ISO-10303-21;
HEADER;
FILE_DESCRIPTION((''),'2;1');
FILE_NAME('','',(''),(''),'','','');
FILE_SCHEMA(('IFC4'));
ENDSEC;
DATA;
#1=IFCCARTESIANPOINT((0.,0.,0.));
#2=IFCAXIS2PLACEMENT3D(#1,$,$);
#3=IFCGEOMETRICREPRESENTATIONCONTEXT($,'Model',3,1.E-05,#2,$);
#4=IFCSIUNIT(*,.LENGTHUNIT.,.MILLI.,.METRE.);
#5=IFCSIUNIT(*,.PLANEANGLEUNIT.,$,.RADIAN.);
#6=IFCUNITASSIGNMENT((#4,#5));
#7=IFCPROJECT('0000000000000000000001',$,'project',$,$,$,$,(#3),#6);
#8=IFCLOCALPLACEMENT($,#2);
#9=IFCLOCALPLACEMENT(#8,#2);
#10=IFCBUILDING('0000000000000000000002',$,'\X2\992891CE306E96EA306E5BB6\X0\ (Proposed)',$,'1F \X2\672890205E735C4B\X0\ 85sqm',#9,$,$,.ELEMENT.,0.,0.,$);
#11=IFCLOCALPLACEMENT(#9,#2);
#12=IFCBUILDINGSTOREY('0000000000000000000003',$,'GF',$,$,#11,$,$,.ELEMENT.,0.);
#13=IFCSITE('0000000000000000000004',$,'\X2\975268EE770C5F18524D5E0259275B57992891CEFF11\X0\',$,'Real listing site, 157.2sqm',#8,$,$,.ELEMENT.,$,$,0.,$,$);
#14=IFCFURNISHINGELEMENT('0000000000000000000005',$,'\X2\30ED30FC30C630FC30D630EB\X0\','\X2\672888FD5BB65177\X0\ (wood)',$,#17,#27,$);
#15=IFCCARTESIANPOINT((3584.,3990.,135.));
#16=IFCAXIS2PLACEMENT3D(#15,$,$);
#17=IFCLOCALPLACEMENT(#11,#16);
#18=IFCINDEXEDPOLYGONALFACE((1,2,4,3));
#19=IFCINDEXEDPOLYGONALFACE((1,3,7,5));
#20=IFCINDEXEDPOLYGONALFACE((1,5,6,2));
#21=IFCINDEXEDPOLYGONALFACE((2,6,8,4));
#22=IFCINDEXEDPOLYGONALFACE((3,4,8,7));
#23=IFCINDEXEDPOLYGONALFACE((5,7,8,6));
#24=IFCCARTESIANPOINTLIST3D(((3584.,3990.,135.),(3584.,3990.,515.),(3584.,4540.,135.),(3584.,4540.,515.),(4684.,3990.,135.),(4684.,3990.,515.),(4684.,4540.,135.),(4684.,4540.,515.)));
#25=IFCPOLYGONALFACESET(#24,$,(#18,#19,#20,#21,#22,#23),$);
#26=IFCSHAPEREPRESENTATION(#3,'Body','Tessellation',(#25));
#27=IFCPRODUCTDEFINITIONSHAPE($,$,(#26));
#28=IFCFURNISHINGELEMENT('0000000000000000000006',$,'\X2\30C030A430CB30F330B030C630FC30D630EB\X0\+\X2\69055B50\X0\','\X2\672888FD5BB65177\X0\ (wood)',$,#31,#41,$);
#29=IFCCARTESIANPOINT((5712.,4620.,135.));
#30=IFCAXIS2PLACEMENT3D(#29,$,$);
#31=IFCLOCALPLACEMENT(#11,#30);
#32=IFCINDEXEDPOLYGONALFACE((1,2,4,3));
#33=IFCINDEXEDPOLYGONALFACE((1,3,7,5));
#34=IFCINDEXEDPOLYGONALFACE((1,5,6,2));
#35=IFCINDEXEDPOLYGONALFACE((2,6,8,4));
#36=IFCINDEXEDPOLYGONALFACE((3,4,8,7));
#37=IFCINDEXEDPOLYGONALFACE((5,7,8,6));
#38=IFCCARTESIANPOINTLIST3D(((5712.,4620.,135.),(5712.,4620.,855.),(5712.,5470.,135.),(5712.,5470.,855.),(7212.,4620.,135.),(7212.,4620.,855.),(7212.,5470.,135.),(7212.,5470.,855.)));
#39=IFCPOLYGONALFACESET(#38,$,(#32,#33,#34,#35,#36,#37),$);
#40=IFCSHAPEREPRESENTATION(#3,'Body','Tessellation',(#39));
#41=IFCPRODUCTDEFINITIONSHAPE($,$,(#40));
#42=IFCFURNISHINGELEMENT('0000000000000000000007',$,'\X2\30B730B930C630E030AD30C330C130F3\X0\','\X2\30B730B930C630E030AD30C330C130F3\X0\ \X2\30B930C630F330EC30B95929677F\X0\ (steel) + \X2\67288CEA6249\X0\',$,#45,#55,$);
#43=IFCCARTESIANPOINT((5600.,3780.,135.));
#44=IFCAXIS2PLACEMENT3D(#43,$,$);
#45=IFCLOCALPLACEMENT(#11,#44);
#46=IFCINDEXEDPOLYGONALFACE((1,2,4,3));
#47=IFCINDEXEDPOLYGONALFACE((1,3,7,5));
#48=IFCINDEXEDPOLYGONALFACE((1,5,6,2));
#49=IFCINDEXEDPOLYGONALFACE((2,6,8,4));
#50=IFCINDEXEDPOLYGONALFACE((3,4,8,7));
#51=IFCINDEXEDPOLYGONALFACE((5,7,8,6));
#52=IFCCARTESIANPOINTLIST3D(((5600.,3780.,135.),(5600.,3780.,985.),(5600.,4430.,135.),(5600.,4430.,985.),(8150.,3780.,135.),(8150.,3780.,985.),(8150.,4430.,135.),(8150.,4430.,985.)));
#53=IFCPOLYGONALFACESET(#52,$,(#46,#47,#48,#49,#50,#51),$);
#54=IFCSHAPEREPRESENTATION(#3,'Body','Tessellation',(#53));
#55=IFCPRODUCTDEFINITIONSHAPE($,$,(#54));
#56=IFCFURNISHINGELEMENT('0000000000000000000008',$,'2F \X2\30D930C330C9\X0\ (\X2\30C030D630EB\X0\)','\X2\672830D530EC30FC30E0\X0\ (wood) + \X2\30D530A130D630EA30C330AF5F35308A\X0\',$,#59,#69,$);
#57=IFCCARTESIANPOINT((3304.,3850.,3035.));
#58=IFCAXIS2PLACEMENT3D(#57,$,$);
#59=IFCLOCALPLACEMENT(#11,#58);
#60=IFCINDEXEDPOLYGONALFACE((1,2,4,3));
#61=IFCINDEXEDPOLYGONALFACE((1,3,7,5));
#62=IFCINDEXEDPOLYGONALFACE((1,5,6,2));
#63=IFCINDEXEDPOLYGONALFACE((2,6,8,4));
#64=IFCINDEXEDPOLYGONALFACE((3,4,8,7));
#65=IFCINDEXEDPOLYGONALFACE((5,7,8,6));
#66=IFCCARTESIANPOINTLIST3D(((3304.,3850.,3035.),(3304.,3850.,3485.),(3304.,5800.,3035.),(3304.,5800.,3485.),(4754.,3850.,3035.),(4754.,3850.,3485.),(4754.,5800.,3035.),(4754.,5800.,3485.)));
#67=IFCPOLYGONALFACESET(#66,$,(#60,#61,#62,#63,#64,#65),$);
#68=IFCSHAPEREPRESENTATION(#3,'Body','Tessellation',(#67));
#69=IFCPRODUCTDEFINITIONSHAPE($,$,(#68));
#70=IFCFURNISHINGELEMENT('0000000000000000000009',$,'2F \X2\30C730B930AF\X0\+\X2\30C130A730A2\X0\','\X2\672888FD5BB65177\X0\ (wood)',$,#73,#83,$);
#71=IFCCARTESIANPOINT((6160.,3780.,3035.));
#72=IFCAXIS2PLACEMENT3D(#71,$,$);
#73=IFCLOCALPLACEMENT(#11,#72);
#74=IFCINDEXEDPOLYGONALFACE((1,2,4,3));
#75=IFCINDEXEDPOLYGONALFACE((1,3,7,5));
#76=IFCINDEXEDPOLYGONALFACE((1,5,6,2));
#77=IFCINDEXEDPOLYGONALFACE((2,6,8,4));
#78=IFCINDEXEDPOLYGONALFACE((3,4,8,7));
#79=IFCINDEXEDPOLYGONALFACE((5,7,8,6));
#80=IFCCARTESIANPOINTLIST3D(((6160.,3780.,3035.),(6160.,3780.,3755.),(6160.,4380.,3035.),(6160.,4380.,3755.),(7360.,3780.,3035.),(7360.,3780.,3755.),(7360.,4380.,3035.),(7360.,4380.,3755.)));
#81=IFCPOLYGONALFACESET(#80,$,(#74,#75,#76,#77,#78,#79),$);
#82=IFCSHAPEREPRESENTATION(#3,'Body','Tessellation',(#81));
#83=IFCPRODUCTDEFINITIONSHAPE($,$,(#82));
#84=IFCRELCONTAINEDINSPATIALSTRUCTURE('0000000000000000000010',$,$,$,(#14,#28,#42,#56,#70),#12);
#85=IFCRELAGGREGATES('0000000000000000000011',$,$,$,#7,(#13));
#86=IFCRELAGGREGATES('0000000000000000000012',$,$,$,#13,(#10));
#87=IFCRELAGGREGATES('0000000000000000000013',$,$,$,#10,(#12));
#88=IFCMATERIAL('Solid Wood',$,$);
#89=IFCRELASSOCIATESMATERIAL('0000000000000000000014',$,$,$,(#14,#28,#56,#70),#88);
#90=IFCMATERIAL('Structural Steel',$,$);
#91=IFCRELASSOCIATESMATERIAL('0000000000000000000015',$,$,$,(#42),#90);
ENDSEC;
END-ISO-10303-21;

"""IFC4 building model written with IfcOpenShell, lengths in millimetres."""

from ifc_helpers import new_model, si_unit, frame, frame_2d, origin, place, context, project, spatial, rectangle, extrude, material, element, save


model = new_model("IFC4")

# Units and contexts
model_context = context("Model", 3, precision=1e-05, world=origin())
ifc_project = project(units=[si_unit("LENGTHUNIT", "METRE", prefix="MILLI"), si_unit("PLANEANGLEUNIT", "RADIAN")], contexts=[model_context])

# Site, building, storey
site_placement = place(None, origin())
site = spatial("IfcSite", under=ifc_project, at=site_placement, Name="青森県弘前市大字館野１", ObjectType="Real listing site, 157.2sqm", CompositionType="ELEMENT", RefElevation=0.0)
building_placement = place(site_placement, origin())
building = spatial("IfcBuilding", under=site, at=building_placement, Name="館野の雪の家 (Proposed)", ObjectType="1F 木造平屋 85sqm", CompositionType="ELEMENT", ElevationOfRefHeight=0.0, ElevationOfTerrain=0.0)
storey_placement = place(building_placement, origin())
storey = spatial("IfcBuildingStorey", under=building, at=storey_placement, Name="GF", CompositionType="ELEMENT", Elevation=0.0)

# Shared definitions
ifc_material_1 = material(Name="Solid Wood")

# Shared definitions
ifc_material_2 = material(Name="Structural Steel")

# Furnishing elements
furnishing_1_placement = place(storey_placement, frame((3584.0, 3990.0, 135.0)))
element("IfcFurnishingElement", 1, at=furnishing_1_placement, inside=storey, material=ifc_material_1, Name="ローテーブル", Description="木製家具 (wood)", context=model_context, shape_type="SweptSolid", body=[
    extrude(rectangle(XDim=1100.0, YDim=550.0, at=frame_2d((550.0, 275.0))), frame((3584.0, 3990.0, 135.0)), (0.0, 0.0, 1.0), 380.0),
])
furnishing_2_placement = place(storey_placement, frame((5712.0, 4620.0, 135.0)))
element("IfcFurnishingElement", 2, at=furnishing_2_placement, inside=storey, material=ifc_material_1, Name="ダイニングテーブル+椅子", Description="木製家具 (wood)", context=model_context, shape_type="SweptSolid", body=[
    extrude(rectangle(XDim=1500.0, YDim=850.0, at=frame_2d((750.0, 425.0))), frame((5712.0, 4620.0, 135.0)), (0.0, 0.0, 1.0), 720.0),
])
furnishing_3_placement = place(storey_placement, frame((5600.0, 3780.0, 135.0)))
element("IfcFurnishingElement", 3, at=furnishing_3_placement, inside=storey, material=ifc_material_2, Name="システムキッチン", Description="システムキッチン ステンレス天板 (steel) + 木質扉", context=model_context, shape_type="SweptSolid", body=[
    extrude(rectangle(XDim=2550.0, YDim=650.0, at=frame_2d((1275.0, 325.0))), frame((5600.0, 3780.0, 135.0)), (0.0, 0.0, 1.0), 850.0),
])
furnishing_4_placement = place(storey_placement, frame((3304.0, 3850.0, 3035.0)))
element("IfcFurnishingElement", 4, at=furnishing_4_placement, inside=storey, material=ifc_material_1, Name="2F ベッド (ダブル)", Description="木フレーム (wood) + ファブリック張り", context=model_context, shape_type="SweptSolid", body=[
    extrude(rectangle(XDim=1450.0, YDim=1950.0, at=frame_2d((725.0, 975.0))), frame((3304.0, 3850.0, 3035.0)), (0.0, 0.0, 1.0), 450.0),
])
furnishing_5_placement = place(storey_placement, frame((6160.0, 3780.0, 3035.0)))
element("IfcFurnishingElement", 5, at=furnishing_5_placement, inside=storey, material=ifc_material_1, Name="2F デスク+チェア", Description="木製家具 (wood)", context=model_context, shape_type="SweptSolid", body=[
    extrude(rectangle(XDim=1200.0, YDim=600.0, at=frame_2d((600.0, 300.0))), frame((6160.0, 3780.0, 3035.0)), (0.0, 0.0, 1.0), 720.0),
])

save(model, "model.ifc")
